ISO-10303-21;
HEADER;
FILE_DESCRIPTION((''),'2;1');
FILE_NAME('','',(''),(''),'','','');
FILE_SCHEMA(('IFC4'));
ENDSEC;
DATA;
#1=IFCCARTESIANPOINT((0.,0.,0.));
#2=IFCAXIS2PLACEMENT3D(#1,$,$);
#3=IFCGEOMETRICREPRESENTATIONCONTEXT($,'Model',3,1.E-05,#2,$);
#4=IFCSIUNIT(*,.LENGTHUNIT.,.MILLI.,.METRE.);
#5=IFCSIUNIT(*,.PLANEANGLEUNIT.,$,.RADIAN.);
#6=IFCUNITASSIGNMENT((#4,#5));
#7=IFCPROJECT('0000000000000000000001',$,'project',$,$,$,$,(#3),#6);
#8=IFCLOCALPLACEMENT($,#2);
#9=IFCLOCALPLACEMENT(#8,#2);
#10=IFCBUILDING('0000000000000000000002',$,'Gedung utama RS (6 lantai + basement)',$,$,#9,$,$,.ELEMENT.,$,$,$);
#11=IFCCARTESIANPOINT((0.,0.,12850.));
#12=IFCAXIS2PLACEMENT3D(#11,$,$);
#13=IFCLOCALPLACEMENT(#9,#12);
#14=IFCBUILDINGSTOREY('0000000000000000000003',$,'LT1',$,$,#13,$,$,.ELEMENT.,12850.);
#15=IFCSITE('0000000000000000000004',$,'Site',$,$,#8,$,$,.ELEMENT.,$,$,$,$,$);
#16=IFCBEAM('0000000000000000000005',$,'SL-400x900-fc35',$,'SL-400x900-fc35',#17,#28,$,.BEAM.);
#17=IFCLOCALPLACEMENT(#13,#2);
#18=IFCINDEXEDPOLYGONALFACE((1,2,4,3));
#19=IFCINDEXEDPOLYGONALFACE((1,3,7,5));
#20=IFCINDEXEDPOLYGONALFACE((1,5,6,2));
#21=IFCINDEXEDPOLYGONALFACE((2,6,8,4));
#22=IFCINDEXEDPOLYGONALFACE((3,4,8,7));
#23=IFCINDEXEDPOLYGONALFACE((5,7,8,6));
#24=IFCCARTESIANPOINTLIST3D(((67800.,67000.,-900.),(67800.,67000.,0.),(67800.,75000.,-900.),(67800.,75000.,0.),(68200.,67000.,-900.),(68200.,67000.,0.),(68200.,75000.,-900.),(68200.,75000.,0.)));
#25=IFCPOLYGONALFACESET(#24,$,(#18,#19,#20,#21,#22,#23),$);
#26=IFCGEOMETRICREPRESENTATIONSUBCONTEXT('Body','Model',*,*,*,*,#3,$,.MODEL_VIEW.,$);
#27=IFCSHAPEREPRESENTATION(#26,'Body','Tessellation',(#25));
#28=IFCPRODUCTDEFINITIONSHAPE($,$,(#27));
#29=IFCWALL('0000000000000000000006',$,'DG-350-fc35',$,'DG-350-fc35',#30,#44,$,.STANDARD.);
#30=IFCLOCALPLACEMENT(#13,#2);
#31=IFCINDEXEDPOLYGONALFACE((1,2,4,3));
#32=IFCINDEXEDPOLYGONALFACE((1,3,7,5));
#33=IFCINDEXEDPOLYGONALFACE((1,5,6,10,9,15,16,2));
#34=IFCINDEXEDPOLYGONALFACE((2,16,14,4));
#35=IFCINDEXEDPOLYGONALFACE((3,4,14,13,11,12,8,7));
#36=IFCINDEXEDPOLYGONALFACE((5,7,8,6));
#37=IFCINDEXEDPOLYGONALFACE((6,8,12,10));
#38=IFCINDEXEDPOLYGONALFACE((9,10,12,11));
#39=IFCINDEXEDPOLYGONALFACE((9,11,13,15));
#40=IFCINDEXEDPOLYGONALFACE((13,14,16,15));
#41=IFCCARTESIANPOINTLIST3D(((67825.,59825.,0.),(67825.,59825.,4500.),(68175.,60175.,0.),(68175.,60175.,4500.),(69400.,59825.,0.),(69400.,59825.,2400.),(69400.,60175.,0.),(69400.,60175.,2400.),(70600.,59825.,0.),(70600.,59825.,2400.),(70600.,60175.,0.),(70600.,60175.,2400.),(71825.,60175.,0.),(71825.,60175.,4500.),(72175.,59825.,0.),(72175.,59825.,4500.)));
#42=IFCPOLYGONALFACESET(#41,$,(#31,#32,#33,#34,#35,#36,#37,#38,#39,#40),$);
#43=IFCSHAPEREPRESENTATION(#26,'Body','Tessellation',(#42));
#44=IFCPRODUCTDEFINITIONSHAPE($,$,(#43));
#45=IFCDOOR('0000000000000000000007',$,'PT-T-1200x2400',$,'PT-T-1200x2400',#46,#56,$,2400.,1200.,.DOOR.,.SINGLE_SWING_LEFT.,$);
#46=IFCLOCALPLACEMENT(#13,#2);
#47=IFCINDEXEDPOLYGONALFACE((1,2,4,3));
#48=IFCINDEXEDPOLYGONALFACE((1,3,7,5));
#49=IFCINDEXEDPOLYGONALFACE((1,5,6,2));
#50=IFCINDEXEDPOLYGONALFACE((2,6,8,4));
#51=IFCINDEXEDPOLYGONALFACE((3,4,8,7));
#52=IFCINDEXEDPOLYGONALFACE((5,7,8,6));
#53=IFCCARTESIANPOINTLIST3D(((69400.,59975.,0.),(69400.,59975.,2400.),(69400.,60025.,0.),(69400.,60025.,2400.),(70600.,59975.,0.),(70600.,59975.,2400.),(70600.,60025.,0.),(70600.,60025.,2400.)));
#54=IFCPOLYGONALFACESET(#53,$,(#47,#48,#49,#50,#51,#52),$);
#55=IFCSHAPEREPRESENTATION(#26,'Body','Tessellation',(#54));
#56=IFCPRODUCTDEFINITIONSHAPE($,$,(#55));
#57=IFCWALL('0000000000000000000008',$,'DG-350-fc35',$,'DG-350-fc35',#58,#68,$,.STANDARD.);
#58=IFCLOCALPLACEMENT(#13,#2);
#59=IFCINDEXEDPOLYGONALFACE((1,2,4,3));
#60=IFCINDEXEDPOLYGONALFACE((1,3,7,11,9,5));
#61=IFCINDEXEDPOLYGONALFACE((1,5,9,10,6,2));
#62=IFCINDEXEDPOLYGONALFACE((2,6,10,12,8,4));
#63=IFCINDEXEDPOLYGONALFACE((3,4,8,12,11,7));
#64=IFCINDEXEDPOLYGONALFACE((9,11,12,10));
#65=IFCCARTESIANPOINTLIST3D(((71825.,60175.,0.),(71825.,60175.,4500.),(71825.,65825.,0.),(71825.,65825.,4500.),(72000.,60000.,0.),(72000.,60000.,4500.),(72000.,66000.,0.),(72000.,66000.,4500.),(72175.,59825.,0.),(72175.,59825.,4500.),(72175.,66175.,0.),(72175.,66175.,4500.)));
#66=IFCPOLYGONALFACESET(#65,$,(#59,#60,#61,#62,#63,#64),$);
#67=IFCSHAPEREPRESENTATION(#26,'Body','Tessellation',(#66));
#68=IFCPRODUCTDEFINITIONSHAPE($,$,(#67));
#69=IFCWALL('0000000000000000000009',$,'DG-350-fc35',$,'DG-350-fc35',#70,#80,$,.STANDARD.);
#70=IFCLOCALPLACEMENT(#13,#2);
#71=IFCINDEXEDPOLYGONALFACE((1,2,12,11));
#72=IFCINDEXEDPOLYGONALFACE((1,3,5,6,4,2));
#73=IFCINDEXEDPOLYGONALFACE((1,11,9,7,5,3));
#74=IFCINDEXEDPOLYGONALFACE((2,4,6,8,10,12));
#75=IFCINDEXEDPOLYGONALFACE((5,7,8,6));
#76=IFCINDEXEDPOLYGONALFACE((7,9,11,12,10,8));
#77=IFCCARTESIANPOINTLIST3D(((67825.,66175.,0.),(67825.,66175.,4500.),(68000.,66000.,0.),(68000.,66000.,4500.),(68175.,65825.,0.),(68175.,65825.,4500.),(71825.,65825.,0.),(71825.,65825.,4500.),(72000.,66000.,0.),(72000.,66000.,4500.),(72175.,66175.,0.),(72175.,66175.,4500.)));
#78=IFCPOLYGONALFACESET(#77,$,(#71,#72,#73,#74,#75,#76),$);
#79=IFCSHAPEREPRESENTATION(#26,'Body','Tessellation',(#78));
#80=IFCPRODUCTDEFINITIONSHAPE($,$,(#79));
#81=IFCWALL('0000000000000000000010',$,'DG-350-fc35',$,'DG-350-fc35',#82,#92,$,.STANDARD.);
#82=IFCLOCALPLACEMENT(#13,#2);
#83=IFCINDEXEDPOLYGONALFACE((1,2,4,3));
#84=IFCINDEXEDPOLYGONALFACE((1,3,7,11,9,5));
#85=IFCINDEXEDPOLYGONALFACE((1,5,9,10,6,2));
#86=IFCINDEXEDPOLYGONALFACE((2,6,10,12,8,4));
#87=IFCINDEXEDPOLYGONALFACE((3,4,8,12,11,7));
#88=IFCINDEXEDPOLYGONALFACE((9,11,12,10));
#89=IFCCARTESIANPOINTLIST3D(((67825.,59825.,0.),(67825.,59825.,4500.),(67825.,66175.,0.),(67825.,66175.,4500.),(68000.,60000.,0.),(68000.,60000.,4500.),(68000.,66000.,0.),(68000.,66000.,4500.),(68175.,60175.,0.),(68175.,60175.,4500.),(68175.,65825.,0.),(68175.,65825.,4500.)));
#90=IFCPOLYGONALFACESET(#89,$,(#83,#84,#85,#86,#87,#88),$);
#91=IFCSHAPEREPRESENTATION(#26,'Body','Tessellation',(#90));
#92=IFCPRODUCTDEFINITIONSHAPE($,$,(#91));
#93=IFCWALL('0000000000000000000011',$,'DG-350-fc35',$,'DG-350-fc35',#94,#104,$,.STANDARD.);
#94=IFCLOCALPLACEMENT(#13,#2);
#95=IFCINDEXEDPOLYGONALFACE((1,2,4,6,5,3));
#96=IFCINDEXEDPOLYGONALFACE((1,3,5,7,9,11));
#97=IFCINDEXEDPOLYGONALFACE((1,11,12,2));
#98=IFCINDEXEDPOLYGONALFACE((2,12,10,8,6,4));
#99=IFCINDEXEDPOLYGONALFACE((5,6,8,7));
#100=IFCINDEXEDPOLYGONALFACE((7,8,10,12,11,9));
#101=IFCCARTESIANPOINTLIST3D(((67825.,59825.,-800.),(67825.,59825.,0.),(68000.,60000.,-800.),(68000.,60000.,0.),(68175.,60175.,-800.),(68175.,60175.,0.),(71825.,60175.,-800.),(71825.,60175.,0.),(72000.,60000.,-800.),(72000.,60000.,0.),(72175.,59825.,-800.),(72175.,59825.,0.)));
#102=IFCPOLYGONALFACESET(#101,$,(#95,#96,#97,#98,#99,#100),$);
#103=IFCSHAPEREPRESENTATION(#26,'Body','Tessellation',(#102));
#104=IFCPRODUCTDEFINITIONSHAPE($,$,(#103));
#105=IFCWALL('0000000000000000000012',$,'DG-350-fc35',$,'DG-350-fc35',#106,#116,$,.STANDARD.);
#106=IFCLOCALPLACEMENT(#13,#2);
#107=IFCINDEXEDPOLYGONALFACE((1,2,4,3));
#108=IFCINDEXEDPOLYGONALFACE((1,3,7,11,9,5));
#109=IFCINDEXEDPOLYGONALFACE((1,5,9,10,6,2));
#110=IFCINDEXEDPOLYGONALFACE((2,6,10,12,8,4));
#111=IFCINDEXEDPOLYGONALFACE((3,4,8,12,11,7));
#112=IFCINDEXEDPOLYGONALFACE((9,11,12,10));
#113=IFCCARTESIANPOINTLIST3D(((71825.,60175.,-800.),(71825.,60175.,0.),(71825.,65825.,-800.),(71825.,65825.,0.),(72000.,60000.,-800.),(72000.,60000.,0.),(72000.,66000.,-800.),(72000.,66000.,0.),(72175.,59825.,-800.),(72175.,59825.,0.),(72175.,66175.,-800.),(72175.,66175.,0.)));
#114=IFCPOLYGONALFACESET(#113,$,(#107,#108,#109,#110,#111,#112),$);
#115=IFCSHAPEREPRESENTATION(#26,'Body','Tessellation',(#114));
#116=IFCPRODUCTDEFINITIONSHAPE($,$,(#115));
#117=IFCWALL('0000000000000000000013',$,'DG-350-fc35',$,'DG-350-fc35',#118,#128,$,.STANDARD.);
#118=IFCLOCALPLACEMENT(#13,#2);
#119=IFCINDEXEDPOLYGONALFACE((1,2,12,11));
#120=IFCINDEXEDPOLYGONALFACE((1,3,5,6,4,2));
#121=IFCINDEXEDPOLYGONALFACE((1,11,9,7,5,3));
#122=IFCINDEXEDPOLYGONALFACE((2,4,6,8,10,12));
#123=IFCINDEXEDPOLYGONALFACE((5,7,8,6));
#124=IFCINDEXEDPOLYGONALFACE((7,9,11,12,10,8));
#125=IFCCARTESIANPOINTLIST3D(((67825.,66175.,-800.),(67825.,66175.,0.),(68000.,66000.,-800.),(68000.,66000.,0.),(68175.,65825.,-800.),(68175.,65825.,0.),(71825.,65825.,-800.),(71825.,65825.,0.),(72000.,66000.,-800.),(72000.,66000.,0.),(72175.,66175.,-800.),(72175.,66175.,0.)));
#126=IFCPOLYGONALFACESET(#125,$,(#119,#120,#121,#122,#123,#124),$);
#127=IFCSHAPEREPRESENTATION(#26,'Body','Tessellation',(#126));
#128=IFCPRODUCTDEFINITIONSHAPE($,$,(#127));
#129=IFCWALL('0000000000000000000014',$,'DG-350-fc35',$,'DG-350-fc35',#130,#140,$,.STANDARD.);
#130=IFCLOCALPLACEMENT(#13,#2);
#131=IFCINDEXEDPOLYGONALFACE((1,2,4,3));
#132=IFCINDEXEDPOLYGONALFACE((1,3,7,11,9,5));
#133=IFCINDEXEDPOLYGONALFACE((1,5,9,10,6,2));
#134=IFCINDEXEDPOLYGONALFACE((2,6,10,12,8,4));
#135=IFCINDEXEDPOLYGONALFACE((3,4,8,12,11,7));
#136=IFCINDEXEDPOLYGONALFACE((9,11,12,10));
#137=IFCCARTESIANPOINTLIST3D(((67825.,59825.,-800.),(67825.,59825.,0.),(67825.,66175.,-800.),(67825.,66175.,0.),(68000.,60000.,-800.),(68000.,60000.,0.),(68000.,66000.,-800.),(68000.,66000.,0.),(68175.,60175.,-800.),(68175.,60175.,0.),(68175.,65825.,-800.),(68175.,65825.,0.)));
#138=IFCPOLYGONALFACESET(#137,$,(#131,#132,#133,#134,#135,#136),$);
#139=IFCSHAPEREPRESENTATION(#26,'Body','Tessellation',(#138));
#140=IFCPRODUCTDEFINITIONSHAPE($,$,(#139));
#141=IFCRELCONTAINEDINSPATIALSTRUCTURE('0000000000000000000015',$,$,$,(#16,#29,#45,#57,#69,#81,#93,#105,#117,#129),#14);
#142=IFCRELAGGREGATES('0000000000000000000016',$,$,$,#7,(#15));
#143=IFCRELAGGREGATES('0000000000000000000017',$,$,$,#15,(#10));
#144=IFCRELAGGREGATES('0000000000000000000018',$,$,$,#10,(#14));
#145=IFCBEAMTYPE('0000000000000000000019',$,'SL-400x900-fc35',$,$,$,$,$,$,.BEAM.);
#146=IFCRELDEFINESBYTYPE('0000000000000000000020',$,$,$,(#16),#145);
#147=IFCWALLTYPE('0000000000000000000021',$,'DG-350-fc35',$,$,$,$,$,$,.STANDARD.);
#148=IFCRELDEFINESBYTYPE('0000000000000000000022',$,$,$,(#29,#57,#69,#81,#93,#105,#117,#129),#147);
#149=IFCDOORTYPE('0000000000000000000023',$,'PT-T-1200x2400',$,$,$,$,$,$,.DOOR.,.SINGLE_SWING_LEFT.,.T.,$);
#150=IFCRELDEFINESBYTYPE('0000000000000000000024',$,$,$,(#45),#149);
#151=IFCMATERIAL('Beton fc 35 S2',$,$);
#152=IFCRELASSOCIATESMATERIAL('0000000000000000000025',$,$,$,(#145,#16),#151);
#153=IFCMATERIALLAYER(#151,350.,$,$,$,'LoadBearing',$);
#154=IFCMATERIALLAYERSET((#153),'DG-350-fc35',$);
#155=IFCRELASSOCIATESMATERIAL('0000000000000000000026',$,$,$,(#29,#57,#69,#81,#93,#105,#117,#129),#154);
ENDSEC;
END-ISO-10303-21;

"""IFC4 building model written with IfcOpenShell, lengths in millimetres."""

from ifc_helpers import new_model, si_unit, frame, frame_2d, origin, origin_2d, place, context, subcontext, project, spatial, polyline, rectangle, outline, extrude, material, layer, layer_set, layer_usage, material_profile, profile_set, profile_usage, type_object, element, fill, save


model = new_model("IFC4")

# Units and contexts
model_context = context("Model", 3, precision=1e-05, world=origin())
body_context = subcontext(model_context, "Body", "Model", "MODEL_VIEW")
ifc_project = project(units=[si_unit("LENGTHUNIT", "METRE", prefix="MILLI"), si_unit("PLANEANGLEUNIT", "RADIAN")], contexts=[model_context])

# Site, building, storey
site_placement = place(None, origin())
site = spatial("IfcSite", under=ifc_project, at=site_placement, Name="Site", CompositionType="ELEMENT")
building_placement = place(site_placement, origin())
building = spatial("IfcBuilding", under=site, at=building_placement, Name="Gedung utama RS (6 lantai + basement)", CompositionType="ELEMENT")
storey_placement = place(building_placement, frame((0.0, 0.0, 12850.0)))
storey = spatial("IfcBuildingStorey", under=building, at=storey_placement, Name="LT1", CompositionType="ELEMENT", Elevation=12850.0)

# Beam
ifc_material = material(Name="Beton fc 35 S2")
ifc_material_profile_1 = material_profile(ifc_material, rectangle(XDim=400.0, YDim=900.0, at=origin_2d()), Name="SL-400x900-fc35")
ifc_profile_set_1 = profile_set([ifc_material_profile_1], Name="SL-400x900-fc35")
ifc_profile_usage_1 = profile_usage(ifc_profile_set_1, cardinal=8)
beam_type_1 = type_object("IfcBeamType", Name="SL-400x900-fc35", PredefinedType="BEAM", material=ifc_profile_set_1)
beam_1_placement = place(storey_placement, frame((68000.0, 67000.0, -450.0)))
element("IfcBeam", 1, at=beam_1_placement, inside=storey, type_object=beam_type_1, material=ifc_profile_usage_1, Name="SL-400x900-fc35", ObjectType="SL-400x900-fc35", PredefinedType="BEAM", context=body_context, shape_type="SweptSolid", body=[
    extrude(rectangle(XDim=400.0, YDim=900.0, at=origin_2d()), frame((0.0, 0.0, 0.0), z_axis=(0.0, 1.0, 0.0), x_axis=(-1.0, 0.0, 0.0)), (0.0, 0.0, 1.0), 8000.0),
])

# Wall, opening, door
ifc_layer = layer(ifc_material, 350.0, Category="LoadBearing")
ifc_layer_set = layer_set([ifc_layer], Name="DG-350-fc35")
ifc_layer_usage = layer_usage(ifc_layer_set, "AXIS2", "NEGATIVE", 175.0)
wall_type = type_object("IfcWallType", Name="DG-350-fc35", PredefinedType="STANDARD")
wall_1_placement = place(storey_placement, frame((68000.0, 60000.0, 0.0), z_axis=(0.0, 0.0, 1.0), x_axis=(1.0, 0.0, 0.0)))
wall_1 = element("IfcWall", 2, at=wall_1_placement, inside=storey, type_object=wall_type, material=ifc_layer_usage, Name="DG-350-fc35", ObjectType="DG-350-fc35", PredefinedType="STANDARD", context=body_context, shape_type="SweptSolid", body=[
    extrude(outline(polyline([(-175.0, -175.0), (0.0, 0.0), (175.0, 175.0), (3825.0, 175.0), (4000.0, 0.0), (4175.0, -175.0), (-175.0, -175.0)])), origin(), (0.0, 0.0, 1.0), 4500.0),
])
opening_placement = place(wall_1_placement, frame((1400.0, 0.0, 0.0), z_axis=(0.0, 0.0, 1.0), x_axis=(1.0, 0.0, 0.0)))
opening = element("IfcOpeningElement", 3, at=opening_placement, cuts=wall_1, PredefinedType="OPENING", context=body_context, shape_type="SweptSolid", body=[
    extrude(rectangle(XDim=1200.0, YDim=370.0, at=frame_2d((600.0, 0.0))), origin(), (0.0, 0.0, 1.0), 2400.0),
])
door_type = type_object("IfcDoorType", Name="PT-T-1200x2400", OperationType="SINGLE_SWING_LEFT", ParameterTakesPrecedence=True, PredefinedType="DOOR")
door_placement = place(opening_placement, origin())
door = element("IfcDoor", 4, at=door_placement, inside=storey, type_object=door_type, Name="PT-T-1200x2400", ObjectType="PT-T-1200x2400", OperationType="SINGLE_SWING_LEFT", OverallHeight=2400.0, OverallWidth=1200.0, PredefinedType="DOOR", context=body_context, shape_type="SweptSolid", body=[
    extrude(rectangle(XDim=1200.0, YDim=50.0, at=frame_2d((600.0, 0.0))), origin(), (0.0, 0.0, 1.0), 2400.0),
])
fill(opening, door)

# Walls
wall_2_placement = place(storey_placement, frame((72000.0, 60000.0, 0.0), z_axis=(0.0, 0.0, 1.0), x_axis=(0.0, 1.0, 0.0)))
element("IfcWall", 5, at=wall_2_placement, inside=storey, type_object=wall_type, material=ifc_layer_usage, Name="DG-350-fc35", ObjectType="DG-350-fc35", PredefinedType="STANDARD", context=body_context, shape_type="SweptSolid", body=[
    extrude(outline(polyline([(-175.0, -175.0), (0.0, 0.0), (175.0, 175.0), (5825.0, 175.0), (6000.0, 0.0), (6175.0, -175.0), (-175.0, -175.0)])), origin(), (0.0, 0.0, 1.0), 4500.0),
])
wall_3_placement = place(storey_placement, frame((72000.0, 66000.0, 0.0), z_axis=(0.0, 0.0, 1.0), x_axis=(-1.0, 0.0, 0.0)))
element("IfcWall", 6, at=wall_3_placement, inside=storey, type_object=wall_type, material=ifc_layer_usage, Name="DG-350-fc35", ObjectType="DG-350-fc35", PredefinedType="STANDARD", context=body_context, shape_type="SweptSolid", body=[
    extrude(outline(polyline([(-175.0, -175.0), (0.0, 0.0), (175.0, 175.0), (3825.0, 175.0), (4000.0, 0.0), (4175.0, -175.0), (-175.0, -175.0)])), origin(), (0.0, 0.0, 1.0), 4500.0),
])
wall_4_placement = place(storey_placement, frame((68000.0, 66000.0, 0.0), z_axis=(0.0, 0.0, 1.0), x_axis=(0.0, -1.0, 0.0)))
element("IfcWall", 7, at=wall_4_placement, inside=storey, type_object=wall_type, material=ifc_layer_usage, Name="DG-350-fc35", ObjectType="DG-350-fc35", PredefinedType="STANDARD", context=body_context, shape_type="SweptSolid", body=[
    extrude(outline(polyline([(-175.0, -175.0), (0.0, 0.0), (175.0, 175.0), (5825.0, 175.0), (6000.0, 0.0), (6175.0, -175.0), (-175.0, -175.0)])), origin(), (0.0, 0.0, 1.0), 4500.0),
])
wall_5_placement = place(storey_placement, frame((68000.0, 60000.0, -800.0), z_axis=(0.0, 0.0, 1.0), x_axis=(1.0, 0.0, 0.0)))
element("IfcWall", 8, at=wall_5_placement, inside=storey, type_object=wall_type, material=ifc_layer_usage, Name="DG-350-fc35", ObjectType="DG-350-fc35", PredefinedType="STANDARD", context=body_context, shape_type="SweptSolid", body=[
    extrude(outline(polyline([(-175.0, -175.0), (0.0, 0.0), (175.0, 175.0), (3825.0, 175.0), (4000.0, 0.0), (4175.0, -175.0), (-175.0, -175.0)])), origin(), (0.0, 0.0, 1.0), 800.0),
])
wall_6_placement = place(storey_placement, frame((72000.0, 60000.0, -800.0), z_axis=(0.0, 0.0, 1.0), x_axis=(0.0, 1.0, 0.0)))
element("IfcWall", 9, at=wall_6_placement, inside=storey, type_object=wall_type, material=ifc_layer_usage, Name="DG-350-fc35", ObjectType="DG-350-fc35", PredefinedType="STANDARD", context=body_context, shape_type="SweptSolid", body=[
    extrude(outline(polyline([(-175.0, -175.0), (0.0, 0.0), (175.0, 175.0), (5825.0, 175.0), (6000.0, 0.0), (6175.0, -175.0), (-175.0, -175.0)])), origin(), (0.0, 0.0, 1.0), 800.0),
])
wall_7_placement = place(storey_placement, frame((72000.0, 66000.0, -800.0), z_axis=(0.0, 0.0, 1.0), x_axis=(-1.0, 0.0, 0.0)))
element("IfcWall", 10, at=wall_7_placement, inside=storey, type_object=wall_type, material=ifc_layer_usage, Name="DG-350-fc35", ObjectType="DG-350-fc35", PredefinedType="STANDARD", context=body_context, shape_type="SweptSolid", body=[
    extrude(outline(polyline([(-175.0, -175.0), (0.0, 0.0), (175.0, 175.0), (3825.0, 175.0), (4000.0, 0.0), (4175.0, -175.0), (-175.0, -175.0)])), origin(), (0.0, 0.0, 1.0), 800.0),
])
wall_8_placement = place(storey_placement, frame((68000.0, 66000.0, -800.0), z_axis=(0.0, 0.0, 1.0), x_axis=(0.0, -1.0, 0.0)))
element("IfcWall", 11, at=wall_8_placement, inside=storey, type_object=wall_type, material=ifc_layer_usage, Name="DG-350-fc35", ObjectType="DG-350-fc35", PredefinedType="STANDARD", context=body_context, shape_type="SweptSolid", body=[
    extrude(outline(polyline([(-175.0, -175.0), (0.0, 0.0), (175.0, 175.0), (5825.0, 175.0), (6000.0, 0.0), (6175.0, -175.0), (-175.0, -175.0)])), origin(), (0.0, 0.0, 1.0), 800.0),
])

save(model, "model.ifc")
